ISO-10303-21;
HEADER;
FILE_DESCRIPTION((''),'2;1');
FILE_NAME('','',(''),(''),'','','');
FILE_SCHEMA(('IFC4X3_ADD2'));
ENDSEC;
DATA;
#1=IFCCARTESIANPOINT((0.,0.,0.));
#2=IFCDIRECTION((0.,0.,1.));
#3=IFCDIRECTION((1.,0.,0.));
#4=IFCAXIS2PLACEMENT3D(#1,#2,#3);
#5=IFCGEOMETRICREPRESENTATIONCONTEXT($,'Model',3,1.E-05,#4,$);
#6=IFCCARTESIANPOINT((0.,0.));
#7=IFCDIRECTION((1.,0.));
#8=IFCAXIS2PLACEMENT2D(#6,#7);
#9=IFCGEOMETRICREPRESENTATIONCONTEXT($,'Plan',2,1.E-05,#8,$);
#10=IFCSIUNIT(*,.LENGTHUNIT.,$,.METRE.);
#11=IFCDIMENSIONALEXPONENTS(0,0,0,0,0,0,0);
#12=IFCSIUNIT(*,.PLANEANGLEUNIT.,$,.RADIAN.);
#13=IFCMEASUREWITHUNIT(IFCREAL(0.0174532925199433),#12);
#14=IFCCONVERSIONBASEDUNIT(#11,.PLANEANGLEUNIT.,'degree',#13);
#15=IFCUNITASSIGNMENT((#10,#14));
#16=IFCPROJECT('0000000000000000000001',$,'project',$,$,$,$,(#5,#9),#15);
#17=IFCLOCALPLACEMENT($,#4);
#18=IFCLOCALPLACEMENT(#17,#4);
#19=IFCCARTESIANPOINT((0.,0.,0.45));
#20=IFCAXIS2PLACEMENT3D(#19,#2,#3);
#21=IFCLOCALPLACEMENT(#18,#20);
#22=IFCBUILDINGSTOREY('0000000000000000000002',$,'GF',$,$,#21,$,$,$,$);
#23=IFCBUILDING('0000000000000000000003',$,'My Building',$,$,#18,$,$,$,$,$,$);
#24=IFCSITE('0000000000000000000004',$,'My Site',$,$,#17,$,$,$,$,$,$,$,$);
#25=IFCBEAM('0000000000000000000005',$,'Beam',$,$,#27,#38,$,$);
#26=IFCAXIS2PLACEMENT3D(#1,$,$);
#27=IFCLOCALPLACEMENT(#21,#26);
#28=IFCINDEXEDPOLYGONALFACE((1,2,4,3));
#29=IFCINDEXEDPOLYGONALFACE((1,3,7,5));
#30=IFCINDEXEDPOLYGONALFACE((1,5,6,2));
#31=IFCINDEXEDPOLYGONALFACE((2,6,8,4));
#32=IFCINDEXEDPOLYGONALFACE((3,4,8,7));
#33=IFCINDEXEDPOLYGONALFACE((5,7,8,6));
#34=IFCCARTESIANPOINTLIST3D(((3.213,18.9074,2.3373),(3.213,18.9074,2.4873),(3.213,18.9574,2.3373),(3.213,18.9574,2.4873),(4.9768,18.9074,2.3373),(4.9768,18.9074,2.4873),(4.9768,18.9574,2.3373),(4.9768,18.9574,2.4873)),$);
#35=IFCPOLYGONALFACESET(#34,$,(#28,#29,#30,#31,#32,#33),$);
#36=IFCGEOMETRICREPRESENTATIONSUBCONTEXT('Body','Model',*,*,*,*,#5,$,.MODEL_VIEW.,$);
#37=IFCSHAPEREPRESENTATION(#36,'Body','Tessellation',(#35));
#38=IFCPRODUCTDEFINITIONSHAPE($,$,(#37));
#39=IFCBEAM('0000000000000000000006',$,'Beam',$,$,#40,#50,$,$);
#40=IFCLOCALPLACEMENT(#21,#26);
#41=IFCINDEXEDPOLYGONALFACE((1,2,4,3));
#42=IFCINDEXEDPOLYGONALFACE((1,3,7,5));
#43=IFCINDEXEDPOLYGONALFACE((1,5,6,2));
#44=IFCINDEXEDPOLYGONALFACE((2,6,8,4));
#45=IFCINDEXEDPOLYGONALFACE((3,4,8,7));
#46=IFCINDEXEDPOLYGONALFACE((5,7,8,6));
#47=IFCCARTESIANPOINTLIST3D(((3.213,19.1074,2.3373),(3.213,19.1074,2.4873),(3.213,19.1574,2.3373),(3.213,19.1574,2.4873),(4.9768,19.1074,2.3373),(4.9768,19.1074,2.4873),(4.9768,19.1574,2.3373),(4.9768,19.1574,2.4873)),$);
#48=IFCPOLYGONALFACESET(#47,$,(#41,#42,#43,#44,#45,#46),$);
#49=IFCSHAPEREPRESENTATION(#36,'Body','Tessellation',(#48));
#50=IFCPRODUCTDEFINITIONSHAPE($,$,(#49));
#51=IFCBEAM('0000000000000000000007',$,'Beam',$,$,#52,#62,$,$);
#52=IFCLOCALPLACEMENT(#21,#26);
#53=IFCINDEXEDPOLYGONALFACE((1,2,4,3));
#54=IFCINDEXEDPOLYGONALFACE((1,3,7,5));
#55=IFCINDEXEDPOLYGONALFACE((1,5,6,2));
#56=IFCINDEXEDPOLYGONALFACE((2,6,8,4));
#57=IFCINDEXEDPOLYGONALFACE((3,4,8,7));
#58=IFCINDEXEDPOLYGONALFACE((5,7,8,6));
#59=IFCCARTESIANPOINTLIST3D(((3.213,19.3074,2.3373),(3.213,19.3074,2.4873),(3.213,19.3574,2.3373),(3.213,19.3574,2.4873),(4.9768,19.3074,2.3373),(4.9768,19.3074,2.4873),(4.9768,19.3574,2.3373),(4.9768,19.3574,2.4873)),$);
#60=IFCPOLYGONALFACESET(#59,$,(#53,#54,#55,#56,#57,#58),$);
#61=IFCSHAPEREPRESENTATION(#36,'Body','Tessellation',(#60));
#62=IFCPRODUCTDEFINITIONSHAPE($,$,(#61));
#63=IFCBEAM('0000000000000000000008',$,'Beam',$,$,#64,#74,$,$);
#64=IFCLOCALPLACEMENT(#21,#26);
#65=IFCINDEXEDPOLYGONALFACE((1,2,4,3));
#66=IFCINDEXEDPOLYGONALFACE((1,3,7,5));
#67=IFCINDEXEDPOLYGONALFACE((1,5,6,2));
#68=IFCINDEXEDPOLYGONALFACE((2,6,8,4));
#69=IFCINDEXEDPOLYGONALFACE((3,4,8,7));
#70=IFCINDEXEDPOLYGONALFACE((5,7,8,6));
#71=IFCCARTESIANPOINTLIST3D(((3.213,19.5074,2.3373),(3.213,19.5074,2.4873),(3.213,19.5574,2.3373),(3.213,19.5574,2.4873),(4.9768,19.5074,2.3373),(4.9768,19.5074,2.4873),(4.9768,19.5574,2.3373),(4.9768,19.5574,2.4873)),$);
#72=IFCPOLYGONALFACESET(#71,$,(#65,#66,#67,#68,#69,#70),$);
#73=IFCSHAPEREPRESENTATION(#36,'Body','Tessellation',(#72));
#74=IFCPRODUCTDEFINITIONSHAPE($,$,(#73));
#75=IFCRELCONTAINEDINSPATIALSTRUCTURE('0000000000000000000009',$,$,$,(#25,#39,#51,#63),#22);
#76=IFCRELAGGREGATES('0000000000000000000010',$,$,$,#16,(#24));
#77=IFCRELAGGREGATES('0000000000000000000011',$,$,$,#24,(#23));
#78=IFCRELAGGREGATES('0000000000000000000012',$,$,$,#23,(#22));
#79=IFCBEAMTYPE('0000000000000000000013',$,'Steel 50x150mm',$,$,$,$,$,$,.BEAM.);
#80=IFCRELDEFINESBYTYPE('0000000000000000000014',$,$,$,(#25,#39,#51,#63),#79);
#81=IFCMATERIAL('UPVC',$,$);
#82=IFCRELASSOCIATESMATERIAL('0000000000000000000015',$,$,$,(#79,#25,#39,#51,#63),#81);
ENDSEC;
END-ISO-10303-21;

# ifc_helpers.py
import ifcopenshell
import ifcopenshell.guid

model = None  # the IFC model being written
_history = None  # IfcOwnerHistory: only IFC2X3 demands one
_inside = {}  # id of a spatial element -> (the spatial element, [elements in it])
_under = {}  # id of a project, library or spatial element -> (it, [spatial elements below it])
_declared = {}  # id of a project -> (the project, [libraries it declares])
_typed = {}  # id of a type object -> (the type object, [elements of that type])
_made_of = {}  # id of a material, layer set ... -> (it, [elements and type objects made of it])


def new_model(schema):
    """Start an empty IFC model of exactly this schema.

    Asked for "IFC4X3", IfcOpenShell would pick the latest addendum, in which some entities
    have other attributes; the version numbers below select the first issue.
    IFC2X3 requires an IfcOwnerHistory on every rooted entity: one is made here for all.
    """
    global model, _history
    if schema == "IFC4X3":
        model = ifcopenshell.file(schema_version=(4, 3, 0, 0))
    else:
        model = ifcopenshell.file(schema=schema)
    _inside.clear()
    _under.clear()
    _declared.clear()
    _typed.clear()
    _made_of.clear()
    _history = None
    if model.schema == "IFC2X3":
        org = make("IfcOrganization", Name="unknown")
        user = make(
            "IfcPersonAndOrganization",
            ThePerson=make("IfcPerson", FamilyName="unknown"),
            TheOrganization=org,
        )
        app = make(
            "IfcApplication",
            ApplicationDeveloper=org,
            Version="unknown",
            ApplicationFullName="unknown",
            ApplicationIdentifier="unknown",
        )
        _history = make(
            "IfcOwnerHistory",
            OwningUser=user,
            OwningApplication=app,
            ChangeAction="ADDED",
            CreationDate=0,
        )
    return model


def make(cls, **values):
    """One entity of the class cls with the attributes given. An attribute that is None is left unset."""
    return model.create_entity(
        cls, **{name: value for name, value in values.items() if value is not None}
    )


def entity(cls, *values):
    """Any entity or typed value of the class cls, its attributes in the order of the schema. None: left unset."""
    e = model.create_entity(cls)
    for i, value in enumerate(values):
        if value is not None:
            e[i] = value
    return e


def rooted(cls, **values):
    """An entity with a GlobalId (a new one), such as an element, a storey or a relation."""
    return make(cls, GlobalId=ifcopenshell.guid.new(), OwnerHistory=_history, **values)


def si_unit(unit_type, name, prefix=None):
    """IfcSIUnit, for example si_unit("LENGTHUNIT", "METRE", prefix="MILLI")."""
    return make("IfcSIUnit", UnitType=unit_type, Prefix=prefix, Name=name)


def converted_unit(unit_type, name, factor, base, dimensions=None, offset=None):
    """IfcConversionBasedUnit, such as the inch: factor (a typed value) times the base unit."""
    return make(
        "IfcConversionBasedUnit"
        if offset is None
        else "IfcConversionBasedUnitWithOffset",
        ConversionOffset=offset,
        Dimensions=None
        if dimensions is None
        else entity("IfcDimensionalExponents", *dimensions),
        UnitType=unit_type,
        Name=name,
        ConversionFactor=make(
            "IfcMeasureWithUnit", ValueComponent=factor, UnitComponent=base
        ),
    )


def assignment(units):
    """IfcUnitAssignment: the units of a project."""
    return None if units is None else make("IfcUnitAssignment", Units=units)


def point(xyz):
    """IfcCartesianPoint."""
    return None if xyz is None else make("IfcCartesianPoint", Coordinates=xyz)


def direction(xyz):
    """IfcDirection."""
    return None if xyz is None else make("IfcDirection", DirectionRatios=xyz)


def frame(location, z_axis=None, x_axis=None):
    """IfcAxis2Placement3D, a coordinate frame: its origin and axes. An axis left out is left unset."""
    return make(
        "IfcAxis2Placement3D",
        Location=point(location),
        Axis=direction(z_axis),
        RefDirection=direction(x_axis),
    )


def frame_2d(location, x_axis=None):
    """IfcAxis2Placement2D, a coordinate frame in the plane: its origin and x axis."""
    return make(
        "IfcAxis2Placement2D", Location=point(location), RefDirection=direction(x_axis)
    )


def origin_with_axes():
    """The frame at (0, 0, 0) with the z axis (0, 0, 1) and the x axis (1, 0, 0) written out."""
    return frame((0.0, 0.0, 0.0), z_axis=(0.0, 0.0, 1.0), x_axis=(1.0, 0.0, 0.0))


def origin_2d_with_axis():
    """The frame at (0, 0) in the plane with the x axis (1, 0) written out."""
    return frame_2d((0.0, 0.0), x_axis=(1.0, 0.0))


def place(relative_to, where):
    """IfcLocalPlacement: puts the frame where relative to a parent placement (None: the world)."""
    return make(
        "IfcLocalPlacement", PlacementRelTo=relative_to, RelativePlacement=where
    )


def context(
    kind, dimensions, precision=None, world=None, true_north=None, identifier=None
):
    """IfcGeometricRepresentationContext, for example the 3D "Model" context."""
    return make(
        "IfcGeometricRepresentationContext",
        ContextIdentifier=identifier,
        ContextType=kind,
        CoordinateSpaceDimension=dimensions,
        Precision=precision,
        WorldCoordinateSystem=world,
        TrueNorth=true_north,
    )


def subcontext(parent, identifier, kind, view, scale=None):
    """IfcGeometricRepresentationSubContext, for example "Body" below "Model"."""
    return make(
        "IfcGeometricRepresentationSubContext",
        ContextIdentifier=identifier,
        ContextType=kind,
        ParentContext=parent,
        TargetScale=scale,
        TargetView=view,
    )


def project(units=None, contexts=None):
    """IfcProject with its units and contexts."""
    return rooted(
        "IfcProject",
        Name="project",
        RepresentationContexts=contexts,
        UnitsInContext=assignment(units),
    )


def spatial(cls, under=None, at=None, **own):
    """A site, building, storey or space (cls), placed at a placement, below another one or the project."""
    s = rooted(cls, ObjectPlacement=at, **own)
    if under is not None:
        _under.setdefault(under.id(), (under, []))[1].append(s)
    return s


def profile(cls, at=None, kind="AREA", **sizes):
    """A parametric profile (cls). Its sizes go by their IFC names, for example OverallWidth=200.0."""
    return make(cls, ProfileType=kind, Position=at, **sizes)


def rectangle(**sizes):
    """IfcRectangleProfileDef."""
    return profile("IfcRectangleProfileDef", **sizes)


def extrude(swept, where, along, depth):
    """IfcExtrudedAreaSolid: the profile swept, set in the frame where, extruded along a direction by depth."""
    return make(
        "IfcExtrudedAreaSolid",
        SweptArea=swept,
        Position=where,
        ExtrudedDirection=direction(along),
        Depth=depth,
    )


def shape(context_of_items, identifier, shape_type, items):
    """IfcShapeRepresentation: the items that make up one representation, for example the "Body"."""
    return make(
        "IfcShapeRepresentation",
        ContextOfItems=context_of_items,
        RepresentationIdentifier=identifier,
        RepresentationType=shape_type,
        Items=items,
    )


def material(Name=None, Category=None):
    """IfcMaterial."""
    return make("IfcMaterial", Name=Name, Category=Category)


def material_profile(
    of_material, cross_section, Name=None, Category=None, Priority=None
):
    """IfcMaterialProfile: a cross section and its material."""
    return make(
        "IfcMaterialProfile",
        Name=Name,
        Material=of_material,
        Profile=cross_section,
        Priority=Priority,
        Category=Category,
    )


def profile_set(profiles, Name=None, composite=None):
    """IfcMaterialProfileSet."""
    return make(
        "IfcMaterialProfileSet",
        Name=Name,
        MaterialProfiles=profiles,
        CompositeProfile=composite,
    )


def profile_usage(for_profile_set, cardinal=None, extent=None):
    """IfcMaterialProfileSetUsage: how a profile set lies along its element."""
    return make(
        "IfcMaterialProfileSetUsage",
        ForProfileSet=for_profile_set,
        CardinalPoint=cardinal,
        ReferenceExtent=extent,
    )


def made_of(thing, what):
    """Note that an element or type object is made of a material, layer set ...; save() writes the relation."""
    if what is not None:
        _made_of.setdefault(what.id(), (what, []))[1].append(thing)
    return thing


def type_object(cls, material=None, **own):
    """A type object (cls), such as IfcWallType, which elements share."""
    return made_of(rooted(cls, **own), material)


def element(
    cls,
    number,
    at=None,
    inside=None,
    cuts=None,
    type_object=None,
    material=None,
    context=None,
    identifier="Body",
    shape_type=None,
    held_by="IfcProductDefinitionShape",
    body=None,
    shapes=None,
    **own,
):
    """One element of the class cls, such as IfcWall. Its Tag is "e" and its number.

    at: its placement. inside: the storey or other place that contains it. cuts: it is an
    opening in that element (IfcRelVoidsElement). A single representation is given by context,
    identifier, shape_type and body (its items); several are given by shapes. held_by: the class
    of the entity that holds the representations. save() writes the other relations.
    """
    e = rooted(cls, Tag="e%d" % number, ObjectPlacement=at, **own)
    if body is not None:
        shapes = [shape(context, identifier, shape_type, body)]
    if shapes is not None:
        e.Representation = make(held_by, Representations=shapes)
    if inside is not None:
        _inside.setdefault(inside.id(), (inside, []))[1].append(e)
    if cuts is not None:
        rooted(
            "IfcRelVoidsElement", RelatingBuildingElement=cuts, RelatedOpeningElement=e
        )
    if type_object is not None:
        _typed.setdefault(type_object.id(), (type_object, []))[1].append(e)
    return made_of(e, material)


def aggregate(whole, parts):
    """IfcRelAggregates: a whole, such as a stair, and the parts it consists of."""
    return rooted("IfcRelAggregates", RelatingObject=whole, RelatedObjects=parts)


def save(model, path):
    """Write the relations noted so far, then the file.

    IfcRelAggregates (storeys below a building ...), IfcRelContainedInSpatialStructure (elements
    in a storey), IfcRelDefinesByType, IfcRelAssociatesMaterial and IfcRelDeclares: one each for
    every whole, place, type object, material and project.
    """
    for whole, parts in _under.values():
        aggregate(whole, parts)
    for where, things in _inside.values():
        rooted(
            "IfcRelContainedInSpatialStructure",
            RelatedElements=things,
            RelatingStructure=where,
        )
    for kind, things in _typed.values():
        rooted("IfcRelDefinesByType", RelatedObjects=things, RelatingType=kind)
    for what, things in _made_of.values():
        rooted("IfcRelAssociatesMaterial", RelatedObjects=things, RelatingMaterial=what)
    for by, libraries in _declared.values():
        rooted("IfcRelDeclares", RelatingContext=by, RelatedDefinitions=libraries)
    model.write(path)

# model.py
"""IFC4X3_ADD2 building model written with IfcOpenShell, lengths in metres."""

from ifc_helpers import new_model, entity, si_unit, converted_unit, frame, origin_with_axes, origin_2d_with_axis, place, context, subcontext, project, spatial, rectangle, extrude, material, material_profile, profile_set, profile_usage, type_object, element, save


model = new_model("IFC4X3_ADD2")

# Units and contexts
model_context = context("Model", 3, precision=1e-05, world=origin_with_axes())
plan_context = context("Plan", 2, precision=1e-05, world=origin_2d_with_axis())
body_context = subcontext(model_context, "Body", "Model", "MODEL_VIEW")
ifc_project = project(units=[si_unit("LENGTHUNIT", "METRE"), converted_unit("PLANEANGLEUNIT", "degree", entity("IfcReal", 0.0174532925199433), si_unit("PLANEANGLEUNIT", "RADIAN"), dimensions=[0, 0, 0, 0, 0, 0, 0])], contexts=[model_context, plan_context])

# Site, building, storey
site_placement = place(None, origin_with_axes())
site = spatial("IfcSite", under=ifc_project, at=site_placement, Name="My Site")
building_placement = place(site_placement, origin_with_axes())
building = spatial("IfcBuilding", under=site, at=building_placement, Name="My Building")
storey_placement = place(building_placement, frame((0.0, 0.0, 0.45), z_axis=(0.0, 0.0, 1.0), x_axis=(1.0, 0.0, 0.0)))
storey = spatial("IfcBuildingStorey", under=building, at=storey_placement, Name="GF")

# Beams
ifc_material = material(Name="UPVC")
ifc_material_profile = material_profile(ifc_material, rectangle(XDim=0.05, YDim=0.15))
ifc_profile_set = profile_set([ifc_material_profile])
beam_type = type_object("IfcBeamType", Name="Steel 50x150mm", PredefinedType="BEAM", material=ifc_profile_set)
ifc_profile_usage_1 = profile_usage(ifc_profile_set)
beam_1_placement = place(storey_placement, frame((3.213, 18.9324, 2.4123), z_axis=(1.0, 0.0, 0.0), x_axis=(0.0, 1.0, 0.0)))
element("IfcBeam", 1, at=beam_1_placement, inside=storey, type_object=beam_type, material=ifc_profile_usage_1, Name="Beam", context=body_context, shape_type="SweptSolid", body=[
    extrude(rectangle(XDim=0.05, YDim=0.15), origin_with_axes(), (0.0, 0.0, 1.0), 1.7638),
])
ifc_profile_usage_2 = profile_usage(ifc_profile_set)
beam_2_placement = place(storey_placement, frame((3.213, 19.1324, 2.4123), z_axis=(1.0, 0.0, 0.0), x_axis=(0.0, 1.0, 0.0)))
element("IfcBeam", 2, at=beam_2_placement, inside=storey, type_object=beam_type, material=ifc_profile_usage_2, Name="Beam", context=body_context, shape_type="SweptSolid", body=[
    extrude(rectangle(XDim=0.05, YDim=0.15), origin_with_axes(), (0.0, 0.0, 1.0), 1.7638),
])
ifc_profile_usage_3 = profile_usage(ifc_profile_set)
beam_3_placement = place(storey_placement, frame((3.213, 19.3324, 2.4123), z_axis=(1.0, 0.0, 0.0), x_axis=(0.0, 1.0, 0.0)))
element("IfcBeam", 3, at=beam_3_placement, inside=storey, type_object=beam_type, material=ifc_profile_usage_3, Name="Beam", context=body_context, shape_type="SweptSolid", body=[
    extrude(rectangle(XDim=0.05, YDim=0.15), origin_with_axes(), (0.0, 0.0, 1.0), 1.7638),
])
ifc_profile_usage_4 = profile_usage(ifc_profile_set)
beam_4_placement = place(storey_placement, frame((3.213, 19.5324, 2.4123), z_axis=(1.0, 0.0, 0.0), x_axis=(0.0, 1.0, 0.0)))
element("IfcBeam", 4, at=beam_4_placement, inside=storey, type_object=beam_type, material=ifc_profile_usage_4, Name="Beam", context=body_context, shape_type="SweptSolid", body=[
    extrude(rectangle(XDim=0.05, YDim=0.15), origin_with_axes(), (0.0, 0.0, 1.0), 1.7638),
])

save(model, "model.ifc")
